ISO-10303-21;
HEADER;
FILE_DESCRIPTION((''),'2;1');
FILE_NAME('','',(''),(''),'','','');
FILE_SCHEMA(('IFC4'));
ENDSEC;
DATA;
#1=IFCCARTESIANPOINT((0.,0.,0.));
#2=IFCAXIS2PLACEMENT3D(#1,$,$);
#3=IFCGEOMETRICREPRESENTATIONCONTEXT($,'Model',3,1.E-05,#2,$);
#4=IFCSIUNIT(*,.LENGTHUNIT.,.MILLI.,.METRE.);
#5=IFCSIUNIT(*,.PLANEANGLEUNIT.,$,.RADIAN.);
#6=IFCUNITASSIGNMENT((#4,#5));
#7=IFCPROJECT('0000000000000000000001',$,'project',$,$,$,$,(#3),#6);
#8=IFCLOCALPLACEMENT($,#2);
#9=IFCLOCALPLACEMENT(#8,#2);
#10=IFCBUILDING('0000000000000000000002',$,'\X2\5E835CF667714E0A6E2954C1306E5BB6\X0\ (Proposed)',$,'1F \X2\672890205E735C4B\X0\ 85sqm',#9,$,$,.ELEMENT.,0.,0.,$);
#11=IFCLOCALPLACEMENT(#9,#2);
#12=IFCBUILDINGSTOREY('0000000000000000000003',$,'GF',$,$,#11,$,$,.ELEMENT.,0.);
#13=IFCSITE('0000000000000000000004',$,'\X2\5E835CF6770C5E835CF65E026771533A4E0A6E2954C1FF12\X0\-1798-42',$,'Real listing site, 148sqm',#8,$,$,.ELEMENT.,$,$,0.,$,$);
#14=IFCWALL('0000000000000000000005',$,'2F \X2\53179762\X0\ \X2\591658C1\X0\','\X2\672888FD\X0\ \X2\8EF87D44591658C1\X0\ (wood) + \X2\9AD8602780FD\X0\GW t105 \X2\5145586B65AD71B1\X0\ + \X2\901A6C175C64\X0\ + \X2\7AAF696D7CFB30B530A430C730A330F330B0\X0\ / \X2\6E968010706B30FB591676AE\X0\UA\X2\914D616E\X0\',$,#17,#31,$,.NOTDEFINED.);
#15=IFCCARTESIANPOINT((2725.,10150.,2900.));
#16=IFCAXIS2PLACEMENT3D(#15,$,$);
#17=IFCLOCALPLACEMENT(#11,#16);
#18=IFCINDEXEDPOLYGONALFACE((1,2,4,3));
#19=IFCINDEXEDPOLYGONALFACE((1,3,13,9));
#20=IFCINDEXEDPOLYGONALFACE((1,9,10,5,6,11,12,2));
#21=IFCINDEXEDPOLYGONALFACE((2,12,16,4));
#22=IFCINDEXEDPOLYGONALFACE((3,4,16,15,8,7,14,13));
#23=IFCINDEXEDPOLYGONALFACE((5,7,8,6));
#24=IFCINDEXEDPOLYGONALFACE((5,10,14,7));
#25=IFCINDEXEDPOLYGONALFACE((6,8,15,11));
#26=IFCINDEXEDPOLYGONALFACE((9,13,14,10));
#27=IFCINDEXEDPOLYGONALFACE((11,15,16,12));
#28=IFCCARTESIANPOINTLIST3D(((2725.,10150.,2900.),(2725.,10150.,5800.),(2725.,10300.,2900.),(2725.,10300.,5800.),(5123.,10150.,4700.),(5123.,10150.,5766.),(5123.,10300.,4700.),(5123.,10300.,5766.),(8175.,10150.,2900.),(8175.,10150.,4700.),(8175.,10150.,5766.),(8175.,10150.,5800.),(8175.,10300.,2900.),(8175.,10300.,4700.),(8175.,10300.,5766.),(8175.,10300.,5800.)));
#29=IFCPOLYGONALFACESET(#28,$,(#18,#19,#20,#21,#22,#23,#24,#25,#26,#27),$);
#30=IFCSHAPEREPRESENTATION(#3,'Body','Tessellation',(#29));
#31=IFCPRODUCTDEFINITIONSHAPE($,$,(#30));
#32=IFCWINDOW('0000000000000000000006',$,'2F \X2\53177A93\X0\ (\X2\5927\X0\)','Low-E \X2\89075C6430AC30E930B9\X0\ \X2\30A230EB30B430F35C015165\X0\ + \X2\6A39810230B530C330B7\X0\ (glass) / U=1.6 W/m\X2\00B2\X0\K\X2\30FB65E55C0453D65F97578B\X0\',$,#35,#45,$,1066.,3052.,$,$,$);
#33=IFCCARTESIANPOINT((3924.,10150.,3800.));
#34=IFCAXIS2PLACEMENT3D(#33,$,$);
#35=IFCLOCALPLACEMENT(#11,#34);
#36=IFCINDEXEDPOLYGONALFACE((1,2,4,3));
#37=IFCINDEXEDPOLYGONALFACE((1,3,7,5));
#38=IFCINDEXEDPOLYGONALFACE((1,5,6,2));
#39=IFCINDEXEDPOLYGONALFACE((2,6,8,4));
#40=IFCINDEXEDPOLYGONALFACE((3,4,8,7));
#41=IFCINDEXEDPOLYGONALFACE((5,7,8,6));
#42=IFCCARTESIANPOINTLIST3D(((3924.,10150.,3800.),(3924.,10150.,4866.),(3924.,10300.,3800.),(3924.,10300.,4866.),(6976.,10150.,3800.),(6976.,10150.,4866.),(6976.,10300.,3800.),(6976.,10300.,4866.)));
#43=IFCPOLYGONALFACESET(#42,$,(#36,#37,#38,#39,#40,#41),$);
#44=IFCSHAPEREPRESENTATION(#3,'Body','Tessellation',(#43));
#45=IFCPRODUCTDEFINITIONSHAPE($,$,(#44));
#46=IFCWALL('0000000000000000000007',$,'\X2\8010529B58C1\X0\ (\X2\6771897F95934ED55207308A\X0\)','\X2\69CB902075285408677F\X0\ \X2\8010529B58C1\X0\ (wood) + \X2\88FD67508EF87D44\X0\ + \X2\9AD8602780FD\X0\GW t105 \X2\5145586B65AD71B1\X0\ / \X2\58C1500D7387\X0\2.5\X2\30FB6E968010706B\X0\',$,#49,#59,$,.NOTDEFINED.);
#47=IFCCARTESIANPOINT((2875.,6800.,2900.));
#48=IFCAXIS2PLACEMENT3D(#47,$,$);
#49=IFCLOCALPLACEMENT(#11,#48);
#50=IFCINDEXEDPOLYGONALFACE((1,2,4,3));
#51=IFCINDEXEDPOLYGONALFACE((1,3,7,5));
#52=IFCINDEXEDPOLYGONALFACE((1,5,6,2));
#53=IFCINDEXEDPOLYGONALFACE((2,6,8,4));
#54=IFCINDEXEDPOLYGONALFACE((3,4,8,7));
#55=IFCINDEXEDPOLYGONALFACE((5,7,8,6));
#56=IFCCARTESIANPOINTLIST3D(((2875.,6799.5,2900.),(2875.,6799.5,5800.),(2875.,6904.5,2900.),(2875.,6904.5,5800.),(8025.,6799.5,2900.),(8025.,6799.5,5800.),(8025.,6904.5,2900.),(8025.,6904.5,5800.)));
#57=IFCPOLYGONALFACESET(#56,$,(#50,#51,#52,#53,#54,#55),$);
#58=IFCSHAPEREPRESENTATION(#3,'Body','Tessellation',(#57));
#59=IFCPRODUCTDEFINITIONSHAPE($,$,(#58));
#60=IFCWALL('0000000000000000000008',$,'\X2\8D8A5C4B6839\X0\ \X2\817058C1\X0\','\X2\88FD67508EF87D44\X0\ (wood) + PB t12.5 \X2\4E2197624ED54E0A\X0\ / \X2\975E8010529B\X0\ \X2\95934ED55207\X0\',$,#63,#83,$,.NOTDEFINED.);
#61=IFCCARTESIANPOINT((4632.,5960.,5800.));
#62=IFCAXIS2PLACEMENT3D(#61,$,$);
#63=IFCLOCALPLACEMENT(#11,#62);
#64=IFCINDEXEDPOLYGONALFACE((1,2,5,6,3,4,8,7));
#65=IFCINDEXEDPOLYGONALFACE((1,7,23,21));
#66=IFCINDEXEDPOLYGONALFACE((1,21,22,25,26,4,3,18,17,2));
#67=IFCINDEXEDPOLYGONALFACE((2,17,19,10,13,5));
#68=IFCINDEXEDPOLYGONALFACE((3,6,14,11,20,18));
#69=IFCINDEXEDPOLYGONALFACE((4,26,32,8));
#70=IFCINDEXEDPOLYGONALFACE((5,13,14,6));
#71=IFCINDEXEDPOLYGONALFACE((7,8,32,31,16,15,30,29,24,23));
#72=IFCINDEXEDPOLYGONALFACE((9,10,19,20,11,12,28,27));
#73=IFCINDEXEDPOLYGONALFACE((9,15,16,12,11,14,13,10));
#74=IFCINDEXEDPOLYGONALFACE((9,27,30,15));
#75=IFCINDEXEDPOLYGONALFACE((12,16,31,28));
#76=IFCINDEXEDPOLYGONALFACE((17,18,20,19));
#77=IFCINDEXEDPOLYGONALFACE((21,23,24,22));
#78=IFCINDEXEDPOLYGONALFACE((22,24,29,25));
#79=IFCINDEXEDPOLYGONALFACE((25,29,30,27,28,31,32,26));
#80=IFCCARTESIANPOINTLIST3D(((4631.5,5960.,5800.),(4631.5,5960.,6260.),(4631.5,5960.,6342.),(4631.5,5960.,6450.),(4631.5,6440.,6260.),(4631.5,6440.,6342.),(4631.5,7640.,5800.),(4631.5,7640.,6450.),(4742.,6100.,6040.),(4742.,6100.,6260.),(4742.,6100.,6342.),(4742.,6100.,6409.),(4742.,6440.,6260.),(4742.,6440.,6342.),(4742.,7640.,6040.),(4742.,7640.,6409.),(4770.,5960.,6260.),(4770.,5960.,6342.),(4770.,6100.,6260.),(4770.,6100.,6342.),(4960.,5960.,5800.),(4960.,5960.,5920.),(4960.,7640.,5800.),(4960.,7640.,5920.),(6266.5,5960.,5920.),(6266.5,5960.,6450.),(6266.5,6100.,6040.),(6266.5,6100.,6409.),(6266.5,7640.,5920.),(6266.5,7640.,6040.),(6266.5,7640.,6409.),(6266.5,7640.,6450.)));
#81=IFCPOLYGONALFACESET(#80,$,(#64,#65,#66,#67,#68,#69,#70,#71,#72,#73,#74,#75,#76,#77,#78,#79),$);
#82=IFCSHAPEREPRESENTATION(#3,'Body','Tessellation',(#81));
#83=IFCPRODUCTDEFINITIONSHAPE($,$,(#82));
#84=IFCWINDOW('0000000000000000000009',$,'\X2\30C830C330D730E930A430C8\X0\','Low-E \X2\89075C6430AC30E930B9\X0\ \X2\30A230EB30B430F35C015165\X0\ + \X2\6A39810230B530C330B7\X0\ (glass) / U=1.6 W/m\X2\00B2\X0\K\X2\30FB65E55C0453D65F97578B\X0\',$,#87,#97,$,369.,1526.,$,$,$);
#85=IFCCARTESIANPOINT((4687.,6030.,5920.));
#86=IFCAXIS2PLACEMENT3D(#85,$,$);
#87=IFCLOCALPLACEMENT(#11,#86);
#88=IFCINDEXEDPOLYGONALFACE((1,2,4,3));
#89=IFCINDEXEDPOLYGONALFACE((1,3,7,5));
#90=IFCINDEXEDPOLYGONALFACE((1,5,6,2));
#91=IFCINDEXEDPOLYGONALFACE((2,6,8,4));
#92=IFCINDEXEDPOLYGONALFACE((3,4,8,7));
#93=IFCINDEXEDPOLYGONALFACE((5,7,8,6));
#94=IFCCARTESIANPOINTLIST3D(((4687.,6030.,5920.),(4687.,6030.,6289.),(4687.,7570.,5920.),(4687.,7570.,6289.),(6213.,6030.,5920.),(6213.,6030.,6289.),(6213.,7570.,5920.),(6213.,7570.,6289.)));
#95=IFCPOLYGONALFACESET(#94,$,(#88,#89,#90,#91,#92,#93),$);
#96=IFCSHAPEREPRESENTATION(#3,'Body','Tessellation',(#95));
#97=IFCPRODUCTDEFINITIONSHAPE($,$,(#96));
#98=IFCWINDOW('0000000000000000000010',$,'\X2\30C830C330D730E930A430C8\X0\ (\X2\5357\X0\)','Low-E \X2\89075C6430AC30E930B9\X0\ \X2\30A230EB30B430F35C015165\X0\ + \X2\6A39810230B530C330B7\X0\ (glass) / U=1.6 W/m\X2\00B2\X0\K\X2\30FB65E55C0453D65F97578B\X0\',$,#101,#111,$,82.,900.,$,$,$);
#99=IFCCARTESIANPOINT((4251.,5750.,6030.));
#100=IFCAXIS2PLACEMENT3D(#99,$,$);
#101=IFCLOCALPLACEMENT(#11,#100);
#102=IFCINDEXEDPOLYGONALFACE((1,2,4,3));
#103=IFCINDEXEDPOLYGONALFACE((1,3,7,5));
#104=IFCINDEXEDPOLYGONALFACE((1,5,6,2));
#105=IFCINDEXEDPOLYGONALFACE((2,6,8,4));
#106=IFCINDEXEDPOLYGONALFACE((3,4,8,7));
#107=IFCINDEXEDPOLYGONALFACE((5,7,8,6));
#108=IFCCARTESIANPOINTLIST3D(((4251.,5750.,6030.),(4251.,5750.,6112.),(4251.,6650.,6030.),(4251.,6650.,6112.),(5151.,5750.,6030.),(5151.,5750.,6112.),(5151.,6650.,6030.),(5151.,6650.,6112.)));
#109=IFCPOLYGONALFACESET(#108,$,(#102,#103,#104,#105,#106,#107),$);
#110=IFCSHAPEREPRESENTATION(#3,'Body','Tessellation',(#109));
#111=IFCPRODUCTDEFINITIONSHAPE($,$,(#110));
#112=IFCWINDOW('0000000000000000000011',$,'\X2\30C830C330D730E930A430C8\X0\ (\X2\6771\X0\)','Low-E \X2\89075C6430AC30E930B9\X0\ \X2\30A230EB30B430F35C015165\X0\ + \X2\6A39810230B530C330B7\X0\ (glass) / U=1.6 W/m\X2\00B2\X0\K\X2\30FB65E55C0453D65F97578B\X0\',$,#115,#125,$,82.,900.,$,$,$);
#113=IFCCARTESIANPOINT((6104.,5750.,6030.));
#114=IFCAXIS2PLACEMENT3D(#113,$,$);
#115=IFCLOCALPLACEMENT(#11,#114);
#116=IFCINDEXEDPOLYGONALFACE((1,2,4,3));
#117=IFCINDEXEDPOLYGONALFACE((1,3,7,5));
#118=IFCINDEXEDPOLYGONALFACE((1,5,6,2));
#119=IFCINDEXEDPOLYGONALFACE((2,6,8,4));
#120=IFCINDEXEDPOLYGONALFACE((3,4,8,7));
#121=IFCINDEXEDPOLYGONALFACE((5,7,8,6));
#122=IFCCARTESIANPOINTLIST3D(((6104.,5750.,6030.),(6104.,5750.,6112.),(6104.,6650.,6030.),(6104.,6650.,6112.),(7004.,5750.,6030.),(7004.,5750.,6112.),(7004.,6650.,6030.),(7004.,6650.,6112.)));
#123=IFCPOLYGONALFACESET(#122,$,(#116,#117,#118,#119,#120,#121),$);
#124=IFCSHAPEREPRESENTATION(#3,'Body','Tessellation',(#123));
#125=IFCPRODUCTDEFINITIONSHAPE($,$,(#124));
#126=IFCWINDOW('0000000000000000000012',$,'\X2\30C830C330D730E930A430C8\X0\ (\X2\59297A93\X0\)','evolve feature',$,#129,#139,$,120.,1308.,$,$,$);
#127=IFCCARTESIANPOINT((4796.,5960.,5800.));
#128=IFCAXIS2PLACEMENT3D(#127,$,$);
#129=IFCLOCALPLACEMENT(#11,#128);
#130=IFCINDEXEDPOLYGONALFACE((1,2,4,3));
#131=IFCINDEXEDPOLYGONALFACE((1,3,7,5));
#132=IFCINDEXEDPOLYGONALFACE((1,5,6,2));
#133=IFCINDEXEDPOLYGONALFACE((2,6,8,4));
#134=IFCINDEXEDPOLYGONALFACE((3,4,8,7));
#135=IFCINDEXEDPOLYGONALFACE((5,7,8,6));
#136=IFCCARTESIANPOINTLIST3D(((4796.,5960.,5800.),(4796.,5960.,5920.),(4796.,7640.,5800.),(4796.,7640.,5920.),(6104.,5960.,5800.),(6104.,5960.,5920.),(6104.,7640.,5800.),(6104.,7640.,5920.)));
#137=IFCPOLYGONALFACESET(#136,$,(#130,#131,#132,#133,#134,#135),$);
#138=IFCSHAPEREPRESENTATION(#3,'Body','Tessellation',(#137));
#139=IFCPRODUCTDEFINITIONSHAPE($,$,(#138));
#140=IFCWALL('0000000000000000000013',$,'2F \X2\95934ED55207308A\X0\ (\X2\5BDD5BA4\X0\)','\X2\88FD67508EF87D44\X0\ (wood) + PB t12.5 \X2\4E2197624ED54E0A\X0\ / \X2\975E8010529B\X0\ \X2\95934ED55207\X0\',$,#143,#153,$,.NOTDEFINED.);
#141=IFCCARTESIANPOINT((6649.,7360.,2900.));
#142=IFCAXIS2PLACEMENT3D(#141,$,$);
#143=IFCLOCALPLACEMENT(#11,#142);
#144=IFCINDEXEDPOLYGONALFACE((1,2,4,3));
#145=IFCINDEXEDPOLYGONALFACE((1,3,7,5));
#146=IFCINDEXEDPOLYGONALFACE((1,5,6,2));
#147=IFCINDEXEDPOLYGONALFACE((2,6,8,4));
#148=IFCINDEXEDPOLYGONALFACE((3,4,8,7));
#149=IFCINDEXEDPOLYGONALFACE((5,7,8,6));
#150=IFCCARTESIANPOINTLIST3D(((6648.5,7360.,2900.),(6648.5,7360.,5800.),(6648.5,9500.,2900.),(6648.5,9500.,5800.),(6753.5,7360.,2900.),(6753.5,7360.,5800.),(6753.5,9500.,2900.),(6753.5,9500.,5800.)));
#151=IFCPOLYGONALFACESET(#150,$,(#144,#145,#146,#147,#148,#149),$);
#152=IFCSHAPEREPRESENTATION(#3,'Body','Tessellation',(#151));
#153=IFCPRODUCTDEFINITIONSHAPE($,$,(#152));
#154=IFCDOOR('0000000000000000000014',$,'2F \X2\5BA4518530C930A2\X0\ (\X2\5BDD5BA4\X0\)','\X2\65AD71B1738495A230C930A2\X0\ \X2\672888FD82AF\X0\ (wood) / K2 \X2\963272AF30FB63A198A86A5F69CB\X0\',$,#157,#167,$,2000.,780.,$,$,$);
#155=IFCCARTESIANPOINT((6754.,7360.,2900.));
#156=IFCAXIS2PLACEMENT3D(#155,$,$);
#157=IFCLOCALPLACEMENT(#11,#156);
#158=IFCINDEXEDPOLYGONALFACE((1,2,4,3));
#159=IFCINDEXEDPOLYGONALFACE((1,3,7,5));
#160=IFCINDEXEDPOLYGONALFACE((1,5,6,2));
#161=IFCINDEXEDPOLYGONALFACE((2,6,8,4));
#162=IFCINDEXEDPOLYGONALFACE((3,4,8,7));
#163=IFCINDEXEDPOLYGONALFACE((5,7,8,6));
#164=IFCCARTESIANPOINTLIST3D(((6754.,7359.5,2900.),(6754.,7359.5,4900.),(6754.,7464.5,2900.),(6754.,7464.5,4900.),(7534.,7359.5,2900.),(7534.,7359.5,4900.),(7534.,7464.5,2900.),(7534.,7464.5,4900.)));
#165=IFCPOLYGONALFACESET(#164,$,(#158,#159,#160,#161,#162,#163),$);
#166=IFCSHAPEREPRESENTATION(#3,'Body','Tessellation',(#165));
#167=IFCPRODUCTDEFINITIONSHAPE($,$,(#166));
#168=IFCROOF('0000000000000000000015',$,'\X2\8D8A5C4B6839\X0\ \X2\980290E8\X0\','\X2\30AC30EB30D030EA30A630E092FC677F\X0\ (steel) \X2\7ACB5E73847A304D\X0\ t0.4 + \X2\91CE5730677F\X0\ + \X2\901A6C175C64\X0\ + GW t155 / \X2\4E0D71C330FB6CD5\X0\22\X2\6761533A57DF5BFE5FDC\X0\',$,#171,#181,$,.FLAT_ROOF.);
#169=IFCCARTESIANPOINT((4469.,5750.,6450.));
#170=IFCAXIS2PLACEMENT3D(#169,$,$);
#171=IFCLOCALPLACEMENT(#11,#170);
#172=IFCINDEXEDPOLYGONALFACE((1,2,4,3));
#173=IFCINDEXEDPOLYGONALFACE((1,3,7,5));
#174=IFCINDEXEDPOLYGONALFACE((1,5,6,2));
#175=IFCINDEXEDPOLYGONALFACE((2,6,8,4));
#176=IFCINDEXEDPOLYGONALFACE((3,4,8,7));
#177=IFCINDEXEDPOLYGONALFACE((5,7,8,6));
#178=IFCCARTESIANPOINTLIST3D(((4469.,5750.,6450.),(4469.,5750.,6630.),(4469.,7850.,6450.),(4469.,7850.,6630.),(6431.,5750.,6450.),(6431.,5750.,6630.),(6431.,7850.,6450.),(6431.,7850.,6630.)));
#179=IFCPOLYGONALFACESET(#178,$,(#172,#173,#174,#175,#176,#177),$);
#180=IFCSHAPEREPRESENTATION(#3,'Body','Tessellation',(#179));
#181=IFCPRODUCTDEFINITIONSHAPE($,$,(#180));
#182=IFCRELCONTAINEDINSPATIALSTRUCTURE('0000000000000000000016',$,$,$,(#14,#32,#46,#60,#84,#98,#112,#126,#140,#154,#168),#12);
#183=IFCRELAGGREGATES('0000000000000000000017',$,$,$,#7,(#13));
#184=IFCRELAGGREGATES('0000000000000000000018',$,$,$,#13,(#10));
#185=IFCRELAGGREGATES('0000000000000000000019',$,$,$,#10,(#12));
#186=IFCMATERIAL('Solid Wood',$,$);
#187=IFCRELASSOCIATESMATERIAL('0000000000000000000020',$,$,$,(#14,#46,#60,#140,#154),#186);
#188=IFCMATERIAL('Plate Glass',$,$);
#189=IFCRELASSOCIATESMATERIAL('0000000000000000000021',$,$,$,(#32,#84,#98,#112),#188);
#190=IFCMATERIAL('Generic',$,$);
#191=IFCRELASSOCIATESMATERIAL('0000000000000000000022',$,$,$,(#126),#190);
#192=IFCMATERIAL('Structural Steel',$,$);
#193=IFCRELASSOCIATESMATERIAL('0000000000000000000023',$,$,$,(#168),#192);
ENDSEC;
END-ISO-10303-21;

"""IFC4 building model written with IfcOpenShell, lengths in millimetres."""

from ifc_helpers import new_model, si_unit, frame, frame_2d, origin, place, context, project, spatial, rectangle, extrude, material, element, fill, save


model = new_model("IFC4")

# Units and contexts
model_context = context("Model", 3, precision=1e-05, world=origin())
ifc_project = project(units=[si_unit("LENGTHUNIT", "METRE", prefix="MILLI"), si_unit("PLANEANGLEUNIT", "RADIAN")], contexts=[model_context])

# Site, building, storey
site_placement = place(None, origin())
site = spatial("IfcSite", under=ifc_project, at=site_placement, Name="広島県広島市東区上温品２-1798-42", ObjectType="Real listing site, 148sqm", CompositionType="ELEMENT", RefElevation=0.0)
building_placement = place(site_placement, origin())
building = spatial("IfcBuilding", under=site, at=building_placement, Name="広島東上温品の家 (Proposed)", ObjectType="1F 木造平屋 85sqm", CompositionType="ELEMENT", ElevationOfRefHeight=0.0, ElevationOfTerrain=0.0)
storey_placement = place(building_placement, origin())
storey = spatial("IfcBuildingStorey", under=building, at=storey_placement, Name="GF", CompositionType="ELEMENT", Elevation=0.0)

# Wall, opening, window
ifc_material_1 = material(Name="Solid Wood")
wall_1_placement = place(storey_placement, frame((2725.0, 10150.0, 2900.0)))
wall_1 = element("IfcWall", 1, at=wall_1_placement, inside=storey, material=ifc_material_1, Name="2F 北面 外壁", Description="木製 軸組外壁 (wood) + 高性能GW t105 充填断熱 + 通気層 + 窯業系サイディング / 準耐火・外皮UA配慮", PredefinedType="NOTDEFINED", context=model_context, shape_type="SweptSolid", body=[
    extrude(rectangle(XDim=5450.0, YDim=150.0, at=frame_2d((2725.0, 75.0))), frame((2725.0, 10150.0, 2900.0)), (0.0, 0.0, 1.0), 2900.0),
])
opening_1_placement = place(storey_placement, frame((3924.0, 10150.0, 3800.0)))
opening_1 = element("IfcOpeningElement", 2, at=opening_1_placement, cuts=wall_1, PredefinedType="NOTDEFINED", context=model_context, shape_type="SweptSolid", body=[
    extrude(rectangle(XDim=3052.0, YDim=150.0, at=frame_2d((1526.0, 75.0))), frame((3924.0, 10150.0, 3800.0)), (0.0, 0.0, 1.0), 1066.0),
])
ifc_material_2 = material(Name="Plate Glass")
window_1_placement = place(storey_placement, frame((3924.0, 10150.0, 3800.0)))
window_1 = element("IfcWindow", 3, at=window_1_placement, inside=storey, material=ifc_material_2, Name="2F 北窓 (大)", Description="Low-E 複層ガラス アルゴン封入 + 樹脂サッシ (glass) / U=1.6 W/m²K・日射取得型", OverallHeight=1066.0, OverallWidth=3052.0, context=model_context, shape_type="SweptSolid", body=[
    extrude(rectangle(XDim=3052.0, YDim=150.0, at=frame_2d((1526.0, 75.0))), frame((3924.0, 10150.0, 3800.0)), (0.0, 0.0, 1.0), 1066.0),
])
fill(opening_1, window_1)

# Wall
wall_2_placement = place(storey_placement, frame((2875.0, 6800.0, 2900.0)))
element("IfcWall", 4, at=wall_2_placement, inside=storey, material=ifc_material_1, Name="耐力壁 (東西間仕切り)", Description="構造用合板 耐力壁 (wood) + 製材軸組 + 高性能GW t105 充填断熱 / 壁倍率2.5・準耐火", PredefinedType="NOTDEFINED", context=model_context, shape_type="SweptSolid", body=[
    extrude(rectangle(XDim=5150.0, YDim=105.0, at=frame_2d((2575.0, 52.0))), frame((2875.0, 6800.0, 2900.0)), (0.0, 0.0, 1.0), 2900.0),
])

# Wall, openings, windows
wall_3_placement = place(storey_placement, frame((4632.0, 5960.0, 5800.0)))
wall_3 = element("IfcWall", 5, at=wall_3_placement, inside=storey, material=ifc_material_1, Name="越屋根 腰壁", Description="製材軸組 (wood) + PB t12.5 両面仕上 / 非耐力 間仕切", PredefinedType="NOTDEFINED", context=model_context, shape_type="SweptSolid", body=[
    extrude(rectangle(XDim=1635.0, YDim=1680.0, at=frame_2d((817.0, 840.0))), frame((4632.0, 5960.0, 5800.0)), (0.0, 0.0, 1.0), 650.0),
])
opening_2_placement = place(storey_placement, frame((4687.0, 6030.0, 5920.0)))
opening_2 = element("IfcOpeningElement", 6, at=opening_2_placement, cuts=wall_3, PredefinedType="NOTDEFINED", context=model_context, shape_type="SweptSolid", body=[
    extrude(rectangle(XDim=1526.0, YDim=1540.0, at=frame_2d((763.0, 770.0))), frame((4687.0, 6030.0, 5920.0)), (0.0, 0.0, 1.0), 369.0),
])
opening_3_placement = place(storey_placement, frame((4251.0, 5750.0, 6030.0)))
opening_3 = element("IfcOpeningElement", 7, at=opening_3_placement, cuts=wall_3, PredefinedType="NOTDEFINED", context=model_context, shape_type="SweptSolid", body=[
    extrude(rectangle(XDim=900.0, YDim=900.0, at=frame_2d((450.0, 450.0))), frame((4251.0, 5750.0, 6030.0)), (0.0, 0.0, 1.0), 82.0),
])
opening_4_placement = place(storey_placement, frame((6104.0, 5750.0, 6030.0)))
opening_4 = element("IfcOpeningElement", 8, at=opening_4_placement, cuts=wall_3, PredefinedType="NOTDEFINED", context=model_context, shape_type="SweptSolid", body=[
    extrude(rectangle(XDim=900.0, YDim=900.0, at=frame_2d((450.0, 450.0))), frame((6104.0, 5750.0, 6030.0)), (0.0, 0.0, 1.0), 82.0),
])
opening_5_placement = place(storey_placement, frame((4796.0, 5960.0, 5800.0)))
opening_5 = element("IfcOpeningElement", 9, at=opening_5_placement, cuts=wall_3, PredefinedType="NOTDEFINED", context=model_context, shape_type="SweptSolid", body=[
    extrude(rectangle(XDim=1308.0, YDim=1680.0, at=frame_2d((654.0, 840.0))), frame((4796.0, 5960.0, 5800.0)), (0.0, 0.0, 1.0), 120.0),
])
window_2_placement = place(storey_placement, frame((4687.0, 6030.0, 5920.0)))
window_2 = element("IfcWindow", 10, at=window_2_placement, inside=storey, material=ifc_material_2, Name="トップライト", Description="Low-E 複層ガラス アルゴン封入 + 樹脂サッシ (glass) / U=1.6 W/m²K・日射取得型", OverallHeight=369.0, OverallWidth=1526.0, context=model_context, shape_type="SweptSolid", body=[
    extrude(rectangle(XDim=1526.0, YDim=1540.0, at=frame_2d((763.0, 770.0))), frame((4687.0, 6030.0, 5920.0)), (0.0, 0.0, 1.0), 369.0),
])
fill(opening_2, window_2)
window_3_placement = place(storey_placement, frame((4251.0, 5750.0, 6030.0)))
window_3 = element("IfcWindow", 11, at=window_3_placement, inside=storey, material=ifc_material_2, Name="トップライト (南)", Description="Low-E 複層ガラス アルゴン封入 + 樹脂サッシ (glass) / U=1.6 W/m²K・日射取得型", OverallHeight=82.0, OverallWidth=900.0, context=model_context, shape_type="SweptSolid", body=[
    extrude(rectangle(XDim=900.0, YDim=900.0, at=frame_2d((450.0, 450.0))), frame((4251.0, 5750.0, 6030.0)), (0.0, 0.0, 1.0), 82.0),
])
fill(opening_3, window_3)
window_4_placement = place(storey_placement, frame((6104.0, 5750.0, 6030.0)))
window_4 = element("IfcWindow", 12, at=window_4_placement, inside=storey, material=ifc_material_2, Name="トップライト (東)", Description="Low-E 複層ガラス アルゴン封入 + 樹脂サッシ (glass) / U=1.6 W/m²K・日射取得型", OverallHeight=82.0, OverallWidth=900.0, context=model_context, shape_type="SweptSolid", body=[
    extrude(rectangle(XDim=900.0, YDim=900.0, at=frame_2d((450.0, 450.0))), frame((6104.0, 5750.0, 6030.0)), (0.0, 0.0, 1.0), 82.0),
])
fill(opening_4, window_4)
ifc_material_3 = material(Name="Generic")
window_5_placement = place(storey_placement, frame((4796.0, 5960.0, 5800.0)))
window_5 = element("IfcWindow", 13, at=window_5_placement, inside=storey, material=ifc_material_3, Name="トップライト (天窓)", Description="evolve feature", OverallHeight=120.0, OverallWidth=1308.0, context=model_context, shape_type="SweptSolid", body=[
    extrude(rectangle(XDim=1308.0, YDim=1680.0, at=frame_2d((654.0, 840.0))), frame((4796.0, 5960.0, 5800.0)), (0.0, 0.0, 1.0), 120.0),
])
fill(opening_5, window_5)

# Wall
wall_4_placement = place(storey_placement, frame((6649.0, 7360.0, 2900.0)))
element("IfcWall", 14, at=wall_4_placement, inside=storey, material=ifc_material_1, Name="2F 間仕切り (寝室)", Description="製材軸組 (wood) + PB t12.5 両面仕上 / 非耐力 間仕切", PredefinedType="NOTDEFINED", context=model_context, shape_type="SweptSolid", body=[
    extrude(rectangle(XDim=105.0, YDim=2140.0, at=frame_2d((52.0, 1070.0))), frame((6649.0, 7360.0, 2900.0)), (0.0, 0.0, 1.0), 2900.0),
])

# Door
door_placement = place(storey_placement, frame((6754.0, 7360.0, 2900.0)))
element("IfcDoor", 15, at=door_placement, inside=storey, material=ifc_material_1, Name="2F 室内ドア (寝室)", Description="断熱玄関ドア 木製芯 (wood) / K2 防犯・採風機構", OverallHeight=2000.0, OverallWidth=780.0, context=model_context, shape_type="SweptSolid", body=[
    extrude(rectangle(XDim=780.0, YDim=105.0, at=frame_2d((390.0, 52.0))), frame((6754.0, 7360.0, 2900.0)), (0.0, 0.0, 1.0), 2000.0),
])

# Roof
ifc_material_4 = material(Name="Structural Steel")
roof_placement = place(storey_placement, frame((4469.0, 5750.0, 6450.0)))
element("IfcRoof", 16, at=roof_placement, inside=storey, material=ifc_material_4, Name="越屋根 頂部", Description="ガルバリウム鋼板 (steel) 立平葺き t0.4 + 野地板 + 通気層 + GW t155 / 不燃・法22条区域対応", PredefinedType="FLAT_ROOF", context=model_context, shape_type="SweptSolid", body=[
    extrude(rectangle(XDim=1962.0, YDim=2100.0, at=frame_2d((981.0, 1050.0))), frame((4469.0, 5750.0, 6450.0)), (0.0, 0.0, 1.0), 180.0),
])

save(model, "model.ifc")
